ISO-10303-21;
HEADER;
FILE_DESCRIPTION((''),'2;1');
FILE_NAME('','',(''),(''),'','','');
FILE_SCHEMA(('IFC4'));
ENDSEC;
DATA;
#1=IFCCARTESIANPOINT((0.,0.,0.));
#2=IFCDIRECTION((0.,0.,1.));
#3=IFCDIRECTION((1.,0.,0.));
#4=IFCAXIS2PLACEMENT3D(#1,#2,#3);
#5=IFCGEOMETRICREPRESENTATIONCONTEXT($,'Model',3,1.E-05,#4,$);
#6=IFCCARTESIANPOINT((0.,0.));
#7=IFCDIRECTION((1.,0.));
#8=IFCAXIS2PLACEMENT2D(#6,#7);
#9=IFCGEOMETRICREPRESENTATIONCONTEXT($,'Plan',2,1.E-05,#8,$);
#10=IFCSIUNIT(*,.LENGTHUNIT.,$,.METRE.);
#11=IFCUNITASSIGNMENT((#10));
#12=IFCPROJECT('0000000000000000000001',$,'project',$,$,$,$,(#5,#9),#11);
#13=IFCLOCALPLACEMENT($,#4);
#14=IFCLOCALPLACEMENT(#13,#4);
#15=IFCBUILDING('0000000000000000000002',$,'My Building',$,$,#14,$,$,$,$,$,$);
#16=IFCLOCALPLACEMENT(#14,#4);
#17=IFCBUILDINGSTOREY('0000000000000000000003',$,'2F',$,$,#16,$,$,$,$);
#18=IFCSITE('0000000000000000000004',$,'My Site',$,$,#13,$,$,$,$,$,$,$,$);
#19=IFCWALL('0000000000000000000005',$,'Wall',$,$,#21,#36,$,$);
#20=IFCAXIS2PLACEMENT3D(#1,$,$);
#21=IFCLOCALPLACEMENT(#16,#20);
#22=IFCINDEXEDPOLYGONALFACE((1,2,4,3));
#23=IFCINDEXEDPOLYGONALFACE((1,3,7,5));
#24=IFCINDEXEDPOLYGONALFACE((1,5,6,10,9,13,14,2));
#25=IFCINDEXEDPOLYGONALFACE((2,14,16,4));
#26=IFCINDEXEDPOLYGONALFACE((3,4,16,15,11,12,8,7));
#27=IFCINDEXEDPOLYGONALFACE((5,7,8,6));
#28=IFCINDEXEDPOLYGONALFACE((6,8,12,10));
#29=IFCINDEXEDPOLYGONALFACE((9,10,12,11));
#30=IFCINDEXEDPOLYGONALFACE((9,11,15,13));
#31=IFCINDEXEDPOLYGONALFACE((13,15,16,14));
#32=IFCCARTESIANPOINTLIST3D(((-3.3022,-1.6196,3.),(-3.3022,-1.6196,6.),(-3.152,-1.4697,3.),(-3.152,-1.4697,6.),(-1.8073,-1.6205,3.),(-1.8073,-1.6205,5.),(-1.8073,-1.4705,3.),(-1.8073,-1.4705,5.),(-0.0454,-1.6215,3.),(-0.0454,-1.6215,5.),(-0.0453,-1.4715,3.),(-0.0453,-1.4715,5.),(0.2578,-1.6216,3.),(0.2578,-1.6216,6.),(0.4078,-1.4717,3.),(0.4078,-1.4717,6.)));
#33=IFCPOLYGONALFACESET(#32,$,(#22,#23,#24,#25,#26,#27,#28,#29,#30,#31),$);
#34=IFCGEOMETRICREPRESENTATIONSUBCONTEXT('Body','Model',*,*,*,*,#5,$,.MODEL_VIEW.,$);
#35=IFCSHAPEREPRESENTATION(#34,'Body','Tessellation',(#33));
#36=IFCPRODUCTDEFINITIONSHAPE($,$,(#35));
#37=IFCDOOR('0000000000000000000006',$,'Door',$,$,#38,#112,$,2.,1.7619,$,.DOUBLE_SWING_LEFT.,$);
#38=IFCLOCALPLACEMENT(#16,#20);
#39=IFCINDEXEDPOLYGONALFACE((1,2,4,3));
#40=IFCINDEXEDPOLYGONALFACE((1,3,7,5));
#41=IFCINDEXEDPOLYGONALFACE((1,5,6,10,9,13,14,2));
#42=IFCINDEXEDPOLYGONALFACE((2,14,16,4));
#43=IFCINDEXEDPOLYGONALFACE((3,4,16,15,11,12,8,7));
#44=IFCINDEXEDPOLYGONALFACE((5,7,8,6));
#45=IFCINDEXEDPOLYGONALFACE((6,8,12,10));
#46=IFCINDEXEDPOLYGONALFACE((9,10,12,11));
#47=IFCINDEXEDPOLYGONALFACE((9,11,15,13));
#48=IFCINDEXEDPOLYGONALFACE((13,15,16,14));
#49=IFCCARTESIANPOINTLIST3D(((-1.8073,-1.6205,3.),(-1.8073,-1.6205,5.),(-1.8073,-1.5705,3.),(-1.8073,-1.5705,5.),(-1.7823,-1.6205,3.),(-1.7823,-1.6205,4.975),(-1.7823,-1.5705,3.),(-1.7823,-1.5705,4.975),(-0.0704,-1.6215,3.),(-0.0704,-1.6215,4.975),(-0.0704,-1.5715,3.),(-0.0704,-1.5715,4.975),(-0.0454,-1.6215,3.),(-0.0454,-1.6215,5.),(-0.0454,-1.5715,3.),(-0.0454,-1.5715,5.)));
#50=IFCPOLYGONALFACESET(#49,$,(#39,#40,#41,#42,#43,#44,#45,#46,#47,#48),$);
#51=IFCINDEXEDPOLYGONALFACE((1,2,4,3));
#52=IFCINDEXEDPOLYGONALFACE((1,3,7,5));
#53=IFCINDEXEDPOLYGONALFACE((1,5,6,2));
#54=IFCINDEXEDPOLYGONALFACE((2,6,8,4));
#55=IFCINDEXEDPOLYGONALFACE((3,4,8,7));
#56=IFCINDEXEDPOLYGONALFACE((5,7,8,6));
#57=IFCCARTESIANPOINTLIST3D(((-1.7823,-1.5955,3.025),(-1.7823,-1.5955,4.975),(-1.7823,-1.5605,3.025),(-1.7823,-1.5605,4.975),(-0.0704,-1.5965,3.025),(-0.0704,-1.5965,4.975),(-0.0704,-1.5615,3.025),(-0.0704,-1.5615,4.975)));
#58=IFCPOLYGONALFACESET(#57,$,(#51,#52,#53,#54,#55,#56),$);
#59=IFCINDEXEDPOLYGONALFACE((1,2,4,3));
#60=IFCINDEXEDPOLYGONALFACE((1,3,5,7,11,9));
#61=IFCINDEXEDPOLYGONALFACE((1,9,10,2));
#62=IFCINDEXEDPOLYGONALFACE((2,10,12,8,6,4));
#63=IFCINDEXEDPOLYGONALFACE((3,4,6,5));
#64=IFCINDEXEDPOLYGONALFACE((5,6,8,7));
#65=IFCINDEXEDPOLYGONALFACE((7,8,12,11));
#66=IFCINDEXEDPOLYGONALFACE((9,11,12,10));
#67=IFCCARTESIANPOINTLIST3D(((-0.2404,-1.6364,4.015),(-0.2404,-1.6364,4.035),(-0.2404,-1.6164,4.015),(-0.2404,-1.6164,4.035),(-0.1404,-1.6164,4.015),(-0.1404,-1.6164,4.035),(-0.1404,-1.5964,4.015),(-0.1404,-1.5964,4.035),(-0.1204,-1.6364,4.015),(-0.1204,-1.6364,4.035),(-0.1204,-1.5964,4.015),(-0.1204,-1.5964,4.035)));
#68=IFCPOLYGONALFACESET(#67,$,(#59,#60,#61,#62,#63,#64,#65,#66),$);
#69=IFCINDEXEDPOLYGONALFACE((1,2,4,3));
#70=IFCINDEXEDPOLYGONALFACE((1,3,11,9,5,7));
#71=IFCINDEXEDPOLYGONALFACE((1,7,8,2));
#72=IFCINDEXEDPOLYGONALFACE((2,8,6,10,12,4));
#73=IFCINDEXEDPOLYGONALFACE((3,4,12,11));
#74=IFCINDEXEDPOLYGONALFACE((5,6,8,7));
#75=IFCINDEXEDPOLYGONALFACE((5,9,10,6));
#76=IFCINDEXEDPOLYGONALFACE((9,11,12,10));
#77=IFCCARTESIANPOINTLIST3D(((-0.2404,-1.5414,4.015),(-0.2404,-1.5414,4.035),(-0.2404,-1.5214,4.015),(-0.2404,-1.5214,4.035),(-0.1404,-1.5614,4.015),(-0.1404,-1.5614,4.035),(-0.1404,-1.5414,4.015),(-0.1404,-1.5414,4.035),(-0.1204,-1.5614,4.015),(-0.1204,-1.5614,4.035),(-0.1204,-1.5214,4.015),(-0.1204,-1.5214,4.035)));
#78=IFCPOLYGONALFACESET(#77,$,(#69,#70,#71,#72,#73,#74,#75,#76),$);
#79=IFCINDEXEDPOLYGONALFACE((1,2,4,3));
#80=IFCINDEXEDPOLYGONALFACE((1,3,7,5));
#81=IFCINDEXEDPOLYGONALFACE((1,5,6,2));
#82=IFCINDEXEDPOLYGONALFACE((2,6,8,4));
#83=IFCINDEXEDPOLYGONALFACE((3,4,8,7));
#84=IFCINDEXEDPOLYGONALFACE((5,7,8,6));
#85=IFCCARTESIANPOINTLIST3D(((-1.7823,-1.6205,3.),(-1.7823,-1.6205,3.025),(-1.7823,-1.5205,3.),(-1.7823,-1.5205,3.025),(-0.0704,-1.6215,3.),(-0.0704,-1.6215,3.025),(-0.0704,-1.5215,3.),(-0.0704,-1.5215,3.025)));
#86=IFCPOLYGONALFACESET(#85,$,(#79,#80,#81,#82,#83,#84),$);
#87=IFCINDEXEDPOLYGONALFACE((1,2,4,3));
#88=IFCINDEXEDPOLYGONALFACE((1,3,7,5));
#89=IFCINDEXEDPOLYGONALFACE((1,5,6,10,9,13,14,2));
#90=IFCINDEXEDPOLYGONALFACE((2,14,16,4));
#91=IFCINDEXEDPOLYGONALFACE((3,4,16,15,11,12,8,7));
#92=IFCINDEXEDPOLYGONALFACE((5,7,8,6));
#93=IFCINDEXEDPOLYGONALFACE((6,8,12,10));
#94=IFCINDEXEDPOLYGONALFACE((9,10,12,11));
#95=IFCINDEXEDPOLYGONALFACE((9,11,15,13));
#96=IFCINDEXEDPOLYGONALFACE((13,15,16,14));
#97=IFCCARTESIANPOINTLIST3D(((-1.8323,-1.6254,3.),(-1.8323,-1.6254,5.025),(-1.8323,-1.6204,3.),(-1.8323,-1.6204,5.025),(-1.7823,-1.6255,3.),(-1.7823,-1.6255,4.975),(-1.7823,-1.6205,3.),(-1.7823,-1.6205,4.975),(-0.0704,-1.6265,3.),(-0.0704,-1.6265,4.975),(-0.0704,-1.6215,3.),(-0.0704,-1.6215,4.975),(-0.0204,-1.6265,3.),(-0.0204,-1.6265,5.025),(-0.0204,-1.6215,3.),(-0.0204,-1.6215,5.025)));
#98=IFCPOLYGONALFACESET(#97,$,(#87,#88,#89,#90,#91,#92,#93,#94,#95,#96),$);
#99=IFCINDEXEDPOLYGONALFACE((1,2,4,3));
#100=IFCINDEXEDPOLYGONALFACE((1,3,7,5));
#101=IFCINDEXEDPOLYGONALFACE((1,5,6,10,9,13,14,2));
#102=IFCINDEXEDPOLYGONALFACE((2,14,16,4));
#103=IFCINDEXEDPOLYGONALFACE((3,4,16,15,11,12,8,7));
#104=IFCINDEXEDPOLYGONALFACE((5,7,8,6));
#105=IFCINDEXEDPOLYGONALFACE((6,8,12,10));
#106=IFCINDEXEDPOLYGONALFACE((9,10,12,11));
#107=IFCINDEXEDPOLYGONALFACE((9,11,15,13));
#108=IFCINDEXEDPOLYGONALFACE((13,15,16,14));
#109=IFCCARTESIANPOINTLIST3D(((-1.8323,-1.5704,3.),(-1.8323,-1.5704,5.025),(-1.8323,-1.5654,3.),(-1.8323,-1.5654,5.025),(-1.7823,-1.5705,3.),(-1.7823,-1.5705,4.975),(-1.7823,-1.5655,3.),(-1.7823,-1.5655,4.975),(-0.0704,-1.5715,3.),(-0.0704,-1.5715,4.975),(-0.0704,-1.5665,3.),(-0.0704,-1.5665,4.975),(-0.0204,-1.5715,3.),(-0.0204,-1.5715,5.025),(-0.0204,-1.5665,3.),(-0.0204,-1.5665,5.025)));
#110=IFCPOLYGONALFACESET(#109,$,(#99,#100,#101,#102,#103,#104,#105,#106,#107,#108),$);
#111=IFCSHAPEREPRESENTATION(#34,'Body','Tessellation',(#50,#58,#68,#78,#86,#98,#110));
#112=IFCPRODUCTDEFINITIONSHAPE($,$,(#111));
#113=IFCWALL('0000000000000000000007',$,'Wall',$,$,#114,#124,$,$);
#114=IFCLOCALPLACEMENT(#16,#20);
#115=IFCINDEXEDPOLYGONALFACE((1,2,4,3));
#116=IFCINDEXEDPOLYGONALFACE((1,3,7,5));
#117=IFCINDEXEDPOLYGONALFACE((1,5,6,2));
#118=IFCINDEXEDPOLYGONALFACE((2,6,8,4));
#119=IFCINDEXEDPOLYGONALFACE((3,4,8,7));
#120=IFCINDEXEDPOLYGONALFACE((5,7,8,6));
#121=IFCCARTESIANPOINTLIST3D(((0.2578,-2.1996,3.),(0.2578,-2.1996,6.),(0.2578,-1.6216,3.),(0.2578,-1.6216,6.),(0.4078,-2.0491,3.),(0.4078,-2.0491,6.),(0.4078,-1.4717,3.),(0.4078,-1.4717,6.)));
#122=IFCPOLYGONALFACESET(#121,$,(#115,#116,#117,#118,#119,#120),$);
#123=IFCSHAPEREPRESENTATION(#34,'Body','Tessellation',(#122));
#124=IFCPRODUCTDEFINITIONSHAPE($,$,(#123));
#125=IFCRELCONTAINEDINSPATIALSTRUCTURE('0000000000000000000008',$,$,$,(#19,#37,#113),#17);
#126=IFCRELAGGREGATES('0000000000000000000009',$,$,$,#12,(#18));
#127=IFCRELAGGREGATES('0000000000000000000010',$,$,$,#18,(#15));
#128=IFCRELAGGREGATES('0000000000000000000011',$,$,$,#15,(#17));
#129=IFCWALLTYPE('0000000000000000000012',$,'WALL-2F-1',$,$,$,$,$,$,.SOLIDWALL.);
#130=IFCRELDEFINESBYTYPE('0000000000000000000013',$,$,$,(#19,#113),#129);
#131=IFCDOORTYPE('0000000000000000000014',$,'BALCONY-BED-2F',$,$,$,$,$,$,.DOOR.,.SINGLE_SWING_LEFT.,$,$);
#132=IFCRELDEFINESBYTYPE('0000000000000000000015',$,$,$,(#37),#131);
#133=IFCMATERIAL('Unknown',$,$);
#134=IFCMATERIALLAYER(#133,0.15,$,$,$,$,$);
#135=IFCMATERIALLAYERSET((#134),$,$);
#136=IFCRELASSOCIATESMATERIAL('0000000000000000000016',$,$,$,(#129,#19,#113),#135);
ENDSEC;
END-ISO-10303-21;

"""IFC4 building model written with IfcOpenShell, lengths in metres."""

from ifc_helpers import new_model, entity, si_unit, frame, origin_with_axes, origin_2d_with_axis, place, context, subcontext, project, spatial, line, indexed_curve, outline, extrude, shape, source, transform, mapped, material, layer, layer_set, layer_usage, type_object, type_shapes, element, fill, save


model = new_model("IFC4")

# Units and contexts
model_context = context("Model", 3, precision=1e-05, world=origin_with_axes())
plan_context = context("Plan", 2, precision=1e-05, world=origin_2d_with_axis())
body_context_1 = subcontext(model_context, "Body", "Model", "MODEL_VIEW")
body_context_2 = subcontext(plan_context, "Body", "Plan", "PLAN_VIEW")
ifc_project = project(units=[si_unit("LENGTHUNIT", "METRE")], contexts=[model_context, plan_context])

# Site, building, storey
site_placement = place(None, origin_with_axes())
site = spatial("IfcSite", under=ifc_project, at=site_placement, Name="My Site")
building_placement = place(site_placement, origin_with_axes())
building = spatial("IfcBuilding", under=site, at=building_placement, Name="My Building")
storey_placement = place(building_placement, origin_with_axes())
storey = spatial("IfcBuildingStorey", under=building, at=storey_placement, Name="2F")

# Shared definitions
ifc_material = material(Name="Unknown")

# Wall, opening, door
ifc_layer_1 = layer(ifc_material, 0.15)
ifc_layer_set_1 = layer_set([ifc_layer_1])
ifc_layer_usage_1 = layer_usage(ifc_layer_set_1, "AXIS2", "POSITIVE", 0.0)
wall_type_1 = type_object("IfcWallType", Name="WALL-2F-1", PredefinedType="SOLIDWALL", material=ifc_layer_set_1)
wall_1_placement = place(storey_placement, frame((-3.3022, -1.6196, 3.0), z_axis=(0.0, 0.0, 1.0), x_axis=(1.0, -0.00057, 0.0)))
wall_1 = element("IfcWall", 1, at=wall_1_placement, inside=storey, type_object=wall_type_1, material=ifc_layer_usage_1, Name="Wall", context=body_context_1, shape_type="SweptSolid", body=[
    extrude(outline(indexed_curve([(0.0, 0.0), (0.1501, 0.15), (3.7099, 0.15), (3.56, 0.0)], segments=[line(1, 2, 3, 4, 1)])), origin_with_axes(), (0.0, 0.0, 1.0), 3.0),
])
shared_shape_1 = source(origin_with_axes(), body_context_1, "Body", "SweptSolid", [
    extrude(outline(indexed_curve([(0.0, 0.0), (1.7619, 0.0), (1.7619, 2.0), (0.0, 2.0)], segments=[line(1, 2, 3, 4, 1)])), frame((0.0, -0.6, 0.0), z_axis=(0.0, -1.0, 0.0), x_axis=(1.0, 0.0, 0.0)), (0.0, 0.0, -1.0), 1.2),
])
opening_1_placement = place(wall_1_placement, frame((1.4948, 0.0, 0.0), z_axis=(0.0, 0.0, 1.0), x_axis=(1.0, 0.0, 0.0)))
opening_1 = element("IfcOpeningElement", 2, at=opening_1_placement, cuts=wall_1, PredefinedType="OPENING", context=body_context_1, shape_type="MappedRepresentation", body=[
    mapped(shared_shape_1, transform((0.0, 0.0, 0.0), x_axis=(1.0, 0.0, 0.0), y_axis=(0.0, 1.0, 0.0), z_axis=(0.0, 0.0, 1.0), scale=1.0)),
])
door_type_1 = type_object("IfcDoorType", Name="BALCONY-BED-2F", OperationType="SINGLE_SWING_LEFT", PredefinedType="DOOR")
shared_shape_2 = source(origin_with_axes(), body_context_1, "Body", "SweptSolid", [
    extrude(outline(indexed_curve([(0.0, 0.0), (0.0, 2.0), (1.7619, 2.0), (1.7619, 0.0), (1.7369, 0.0), (1.7369, 1.975), (0.025, 1.975), (0.025, 0.0)], segments=[line(1, 2, 3, 4, 5, 6, 7, 8, 1)])), frame((0.0, 0.0, 0.0), z_axis=(0.0, -1.0, 0.0), x_axis=(1.0, 0.0, 0.0)), (0.0, 0.0, -1.0), 0.05),
    extrude(outline(indexed_curve([(0.0, 0.0), (1.7119, 0.0), (1.7119, 0.035), (0.0, 0.035)], segments=[line(1, 2, 3, 4, 1)])), frame((0.025, 0.025, 0.025), z_axis=(0.0, 0.0, 1.0), x_axis=(1.0, 0.0, 0.0)), (0.0, 0.0, 1.0), 1.95),
    extrude(outline(indexed_curve([(0.0, 0.0), (0.0, -0.04), (-0.12, -0.04), (-0.12, -0.02), (-0.02, -0.02), (-0.02, 0.0)], segments=[line(1, 2, 3, 4, 5, 6, 1)])), frame((1.6869, 0.025, 1.015), z_axis=(0.0, 0.0, 1.0), x_axis=(1.0, 0.0, 0.0)), (0.0, 0.0, 1.0), 0.02),
    extrude(outline(indexed_curve([(0.0, 0.0), (0.0, 0.04), (-0.12, 0.04), (-0.12, 0.02), (-0.02, 0.02), (-0.02, 0.0)], segments=[line(1, 2, 3, 4, 5, 6, 1)])), frame((1.6869, 0.06, 1.015), z_axis=(0.0, 0.0, 1.0), x_axis=(1.0, 0.0, 0.0)), (0.0, 0.0, 1.0), 0.02),
    extrude(outline(indexed_curve([(0.0, 0.0), (1.7119, 0.0), (1.7119, 0.1), (0.0, 0.1)], segments=[line(1, 2, 3, 4, 1)])), frame((0.025, 0.0, 0.0), z_axis=(0.0, 0.0, 1.0), x_axis=(1.0, 0.0, 0.0)), (0.0, 0.0, 1.0), 0.025),
    extrude(outline(indexed_curve([(0.0, 0.0), (0.0, 2.025), (1.8119, 2.025), (1.8119, 0.0), (1.7619, 0.0), (1.7619, 1.975), (0.05, 1.975), (0.05, 0.0)], segments=[line(1, 2, 3, 4, 5, 6, 7, 8, 1)])), frame((-0.025, -0.005, 0.0), z_axis=(0.0, -1.0, 0.0), x_axis=(1.0, 0.0, 0.0)), (0.0, 0.0, -1.0), 0.005),
    extrude(outline(indexed_curve([(0.0, 0.0), (0.0, 2.025), (1.8119, 2.025), (1.8119, 0.0), (1.7619, 0.0), (1.7619, 1.975), (0.05, 1.975), (0.05, 0.0)], segments=[line(1, 2, 3, 4, 5, 6, 7, 8, 1)])), frame((-0.025, 0.05, 0.0), z_axis=(0.0, -1.0, 0.0), x_axis=(1.0, 0.0, 0.0)), (0.0, 0.0, -1.0), 0.005),
])
shared_shape_3 = source(origin_with_axes(), body_context_2, "Body", "Curve2D", [
    entity("IfcIndexedPolyCurve", entity("IfcCartesianPointList2D", [[0.0, 0.0], [0.025, 0.0], [0.025, 0.05], [0.0, 0.05]]), [entity("IfcLineIndex", [1, 2, 3, 4, 1])]),
    entity("IfcIndexedPolyCurve", entity("IfcCartesianPointList2D", [[1.7619, 0.0], [1.7369, 0.0], [1.7369, 0.05], [1.7619, 0.05]]), [entity("IfcLineIndex", [1, 2, 3, 4, 1])]),
    entity("IfcIndexedPolyCurve", entity("IfcCartesianPointList2D", [[0.025, 0.05], [0.025, -1.6619], [0.06, -1.6619]])),
    entity("IfcTrimmedCurve", entity("IfcEllipse", entity("IfcAxis2Placement2D", entity("IfcCartesianPoint", [0.06, 0.05]), entity("IfcDirection", [1.0, 0.0])), 1.6769, 1.7119), [entity("IfcCartesianPoint", [0.06, -1.6619])], [entity("IfcCartesianPoint", [0.06, 1.7619])], True, "CARTESIAN"),
    entity("IfcIndexedPolyCurve", entity("IfcCartesianPointList2D", [[0.025, 0.05], [0.06, 0.05], [0.06, 1.7619], [0.025, 1.7619]]), [entity("IfcLineIndex", [1, 2, 3, 4, 1])]),
])
type_shapes(door_type_1, [shared_shape_2, shared_shape_3])
door_1_placement = place(opening_1_placement, frame((0.0, 0.0, 0.0), z_axis=(0.0, 0.0, 1.0), x_axis=(1.0, 0.0, 0.0)))
door_1 = element("IfcDoor", 3, at=door_1_placement, inside=storey, type_object=door_type_1, Name="Door", OperationType="DOUBLE_SWING_LEFT", OverallHeight=2.0, OverallWidth=1.7619, shapes=[
    shape(body_context_1, "Body", "MappedRepresentation", [mapped(shared_shape_2, transform((0.0, 0.0, 0.0), x_axis=(1.0, 0.0, 0.0), y_axis=(0.0, 1.0, 0.0), z_axis=(0.0, 0.0, 1.0), scale=1.0))]),
    shape(body_context_2, "Body", "MappedRepresentation", [mapped(shared_shape_3, transform((0.0, 0.0, 0.0), x_axis=(1.0, 0.0, 0.0), y_axis=(0.0, 1.0, 0.0), z_axis=(0.0, 0.0, 1.0), scale=1.0))]),
])
fill(opening_1, door_1)

# Wall
ifc_layer_usage_2 = layer_usage(ifc_layer_set_1, "AXIS2", "POSITIVE", 0.0)
wall_2_placement = place(storey_placement, frame((0.2578, -1.6216, 3.0), z_axis=(0.0, 0.0, 1.0), x_axis=(0.0, -1.0, 0.0)))
element("IfcWall", 4, at=wall_2_placement, inside=storey, type_object=wall_type_1, material=ifc_layer_usage_2, Name="Wall", context=body_context_1, shape_type="SweptSolid", body=[
    extrude(outline(indexed_curve([(0.0, 0.0), (-0.1499, 0.15), (0.4275, 0.15), (0.578, 0.0)], segments=[line(1, 2, 3, 4, 1)])), origin_with_axes(), (0.0, 0.0, 1.0), 3.0),
])

save(model, "model.ifc")
